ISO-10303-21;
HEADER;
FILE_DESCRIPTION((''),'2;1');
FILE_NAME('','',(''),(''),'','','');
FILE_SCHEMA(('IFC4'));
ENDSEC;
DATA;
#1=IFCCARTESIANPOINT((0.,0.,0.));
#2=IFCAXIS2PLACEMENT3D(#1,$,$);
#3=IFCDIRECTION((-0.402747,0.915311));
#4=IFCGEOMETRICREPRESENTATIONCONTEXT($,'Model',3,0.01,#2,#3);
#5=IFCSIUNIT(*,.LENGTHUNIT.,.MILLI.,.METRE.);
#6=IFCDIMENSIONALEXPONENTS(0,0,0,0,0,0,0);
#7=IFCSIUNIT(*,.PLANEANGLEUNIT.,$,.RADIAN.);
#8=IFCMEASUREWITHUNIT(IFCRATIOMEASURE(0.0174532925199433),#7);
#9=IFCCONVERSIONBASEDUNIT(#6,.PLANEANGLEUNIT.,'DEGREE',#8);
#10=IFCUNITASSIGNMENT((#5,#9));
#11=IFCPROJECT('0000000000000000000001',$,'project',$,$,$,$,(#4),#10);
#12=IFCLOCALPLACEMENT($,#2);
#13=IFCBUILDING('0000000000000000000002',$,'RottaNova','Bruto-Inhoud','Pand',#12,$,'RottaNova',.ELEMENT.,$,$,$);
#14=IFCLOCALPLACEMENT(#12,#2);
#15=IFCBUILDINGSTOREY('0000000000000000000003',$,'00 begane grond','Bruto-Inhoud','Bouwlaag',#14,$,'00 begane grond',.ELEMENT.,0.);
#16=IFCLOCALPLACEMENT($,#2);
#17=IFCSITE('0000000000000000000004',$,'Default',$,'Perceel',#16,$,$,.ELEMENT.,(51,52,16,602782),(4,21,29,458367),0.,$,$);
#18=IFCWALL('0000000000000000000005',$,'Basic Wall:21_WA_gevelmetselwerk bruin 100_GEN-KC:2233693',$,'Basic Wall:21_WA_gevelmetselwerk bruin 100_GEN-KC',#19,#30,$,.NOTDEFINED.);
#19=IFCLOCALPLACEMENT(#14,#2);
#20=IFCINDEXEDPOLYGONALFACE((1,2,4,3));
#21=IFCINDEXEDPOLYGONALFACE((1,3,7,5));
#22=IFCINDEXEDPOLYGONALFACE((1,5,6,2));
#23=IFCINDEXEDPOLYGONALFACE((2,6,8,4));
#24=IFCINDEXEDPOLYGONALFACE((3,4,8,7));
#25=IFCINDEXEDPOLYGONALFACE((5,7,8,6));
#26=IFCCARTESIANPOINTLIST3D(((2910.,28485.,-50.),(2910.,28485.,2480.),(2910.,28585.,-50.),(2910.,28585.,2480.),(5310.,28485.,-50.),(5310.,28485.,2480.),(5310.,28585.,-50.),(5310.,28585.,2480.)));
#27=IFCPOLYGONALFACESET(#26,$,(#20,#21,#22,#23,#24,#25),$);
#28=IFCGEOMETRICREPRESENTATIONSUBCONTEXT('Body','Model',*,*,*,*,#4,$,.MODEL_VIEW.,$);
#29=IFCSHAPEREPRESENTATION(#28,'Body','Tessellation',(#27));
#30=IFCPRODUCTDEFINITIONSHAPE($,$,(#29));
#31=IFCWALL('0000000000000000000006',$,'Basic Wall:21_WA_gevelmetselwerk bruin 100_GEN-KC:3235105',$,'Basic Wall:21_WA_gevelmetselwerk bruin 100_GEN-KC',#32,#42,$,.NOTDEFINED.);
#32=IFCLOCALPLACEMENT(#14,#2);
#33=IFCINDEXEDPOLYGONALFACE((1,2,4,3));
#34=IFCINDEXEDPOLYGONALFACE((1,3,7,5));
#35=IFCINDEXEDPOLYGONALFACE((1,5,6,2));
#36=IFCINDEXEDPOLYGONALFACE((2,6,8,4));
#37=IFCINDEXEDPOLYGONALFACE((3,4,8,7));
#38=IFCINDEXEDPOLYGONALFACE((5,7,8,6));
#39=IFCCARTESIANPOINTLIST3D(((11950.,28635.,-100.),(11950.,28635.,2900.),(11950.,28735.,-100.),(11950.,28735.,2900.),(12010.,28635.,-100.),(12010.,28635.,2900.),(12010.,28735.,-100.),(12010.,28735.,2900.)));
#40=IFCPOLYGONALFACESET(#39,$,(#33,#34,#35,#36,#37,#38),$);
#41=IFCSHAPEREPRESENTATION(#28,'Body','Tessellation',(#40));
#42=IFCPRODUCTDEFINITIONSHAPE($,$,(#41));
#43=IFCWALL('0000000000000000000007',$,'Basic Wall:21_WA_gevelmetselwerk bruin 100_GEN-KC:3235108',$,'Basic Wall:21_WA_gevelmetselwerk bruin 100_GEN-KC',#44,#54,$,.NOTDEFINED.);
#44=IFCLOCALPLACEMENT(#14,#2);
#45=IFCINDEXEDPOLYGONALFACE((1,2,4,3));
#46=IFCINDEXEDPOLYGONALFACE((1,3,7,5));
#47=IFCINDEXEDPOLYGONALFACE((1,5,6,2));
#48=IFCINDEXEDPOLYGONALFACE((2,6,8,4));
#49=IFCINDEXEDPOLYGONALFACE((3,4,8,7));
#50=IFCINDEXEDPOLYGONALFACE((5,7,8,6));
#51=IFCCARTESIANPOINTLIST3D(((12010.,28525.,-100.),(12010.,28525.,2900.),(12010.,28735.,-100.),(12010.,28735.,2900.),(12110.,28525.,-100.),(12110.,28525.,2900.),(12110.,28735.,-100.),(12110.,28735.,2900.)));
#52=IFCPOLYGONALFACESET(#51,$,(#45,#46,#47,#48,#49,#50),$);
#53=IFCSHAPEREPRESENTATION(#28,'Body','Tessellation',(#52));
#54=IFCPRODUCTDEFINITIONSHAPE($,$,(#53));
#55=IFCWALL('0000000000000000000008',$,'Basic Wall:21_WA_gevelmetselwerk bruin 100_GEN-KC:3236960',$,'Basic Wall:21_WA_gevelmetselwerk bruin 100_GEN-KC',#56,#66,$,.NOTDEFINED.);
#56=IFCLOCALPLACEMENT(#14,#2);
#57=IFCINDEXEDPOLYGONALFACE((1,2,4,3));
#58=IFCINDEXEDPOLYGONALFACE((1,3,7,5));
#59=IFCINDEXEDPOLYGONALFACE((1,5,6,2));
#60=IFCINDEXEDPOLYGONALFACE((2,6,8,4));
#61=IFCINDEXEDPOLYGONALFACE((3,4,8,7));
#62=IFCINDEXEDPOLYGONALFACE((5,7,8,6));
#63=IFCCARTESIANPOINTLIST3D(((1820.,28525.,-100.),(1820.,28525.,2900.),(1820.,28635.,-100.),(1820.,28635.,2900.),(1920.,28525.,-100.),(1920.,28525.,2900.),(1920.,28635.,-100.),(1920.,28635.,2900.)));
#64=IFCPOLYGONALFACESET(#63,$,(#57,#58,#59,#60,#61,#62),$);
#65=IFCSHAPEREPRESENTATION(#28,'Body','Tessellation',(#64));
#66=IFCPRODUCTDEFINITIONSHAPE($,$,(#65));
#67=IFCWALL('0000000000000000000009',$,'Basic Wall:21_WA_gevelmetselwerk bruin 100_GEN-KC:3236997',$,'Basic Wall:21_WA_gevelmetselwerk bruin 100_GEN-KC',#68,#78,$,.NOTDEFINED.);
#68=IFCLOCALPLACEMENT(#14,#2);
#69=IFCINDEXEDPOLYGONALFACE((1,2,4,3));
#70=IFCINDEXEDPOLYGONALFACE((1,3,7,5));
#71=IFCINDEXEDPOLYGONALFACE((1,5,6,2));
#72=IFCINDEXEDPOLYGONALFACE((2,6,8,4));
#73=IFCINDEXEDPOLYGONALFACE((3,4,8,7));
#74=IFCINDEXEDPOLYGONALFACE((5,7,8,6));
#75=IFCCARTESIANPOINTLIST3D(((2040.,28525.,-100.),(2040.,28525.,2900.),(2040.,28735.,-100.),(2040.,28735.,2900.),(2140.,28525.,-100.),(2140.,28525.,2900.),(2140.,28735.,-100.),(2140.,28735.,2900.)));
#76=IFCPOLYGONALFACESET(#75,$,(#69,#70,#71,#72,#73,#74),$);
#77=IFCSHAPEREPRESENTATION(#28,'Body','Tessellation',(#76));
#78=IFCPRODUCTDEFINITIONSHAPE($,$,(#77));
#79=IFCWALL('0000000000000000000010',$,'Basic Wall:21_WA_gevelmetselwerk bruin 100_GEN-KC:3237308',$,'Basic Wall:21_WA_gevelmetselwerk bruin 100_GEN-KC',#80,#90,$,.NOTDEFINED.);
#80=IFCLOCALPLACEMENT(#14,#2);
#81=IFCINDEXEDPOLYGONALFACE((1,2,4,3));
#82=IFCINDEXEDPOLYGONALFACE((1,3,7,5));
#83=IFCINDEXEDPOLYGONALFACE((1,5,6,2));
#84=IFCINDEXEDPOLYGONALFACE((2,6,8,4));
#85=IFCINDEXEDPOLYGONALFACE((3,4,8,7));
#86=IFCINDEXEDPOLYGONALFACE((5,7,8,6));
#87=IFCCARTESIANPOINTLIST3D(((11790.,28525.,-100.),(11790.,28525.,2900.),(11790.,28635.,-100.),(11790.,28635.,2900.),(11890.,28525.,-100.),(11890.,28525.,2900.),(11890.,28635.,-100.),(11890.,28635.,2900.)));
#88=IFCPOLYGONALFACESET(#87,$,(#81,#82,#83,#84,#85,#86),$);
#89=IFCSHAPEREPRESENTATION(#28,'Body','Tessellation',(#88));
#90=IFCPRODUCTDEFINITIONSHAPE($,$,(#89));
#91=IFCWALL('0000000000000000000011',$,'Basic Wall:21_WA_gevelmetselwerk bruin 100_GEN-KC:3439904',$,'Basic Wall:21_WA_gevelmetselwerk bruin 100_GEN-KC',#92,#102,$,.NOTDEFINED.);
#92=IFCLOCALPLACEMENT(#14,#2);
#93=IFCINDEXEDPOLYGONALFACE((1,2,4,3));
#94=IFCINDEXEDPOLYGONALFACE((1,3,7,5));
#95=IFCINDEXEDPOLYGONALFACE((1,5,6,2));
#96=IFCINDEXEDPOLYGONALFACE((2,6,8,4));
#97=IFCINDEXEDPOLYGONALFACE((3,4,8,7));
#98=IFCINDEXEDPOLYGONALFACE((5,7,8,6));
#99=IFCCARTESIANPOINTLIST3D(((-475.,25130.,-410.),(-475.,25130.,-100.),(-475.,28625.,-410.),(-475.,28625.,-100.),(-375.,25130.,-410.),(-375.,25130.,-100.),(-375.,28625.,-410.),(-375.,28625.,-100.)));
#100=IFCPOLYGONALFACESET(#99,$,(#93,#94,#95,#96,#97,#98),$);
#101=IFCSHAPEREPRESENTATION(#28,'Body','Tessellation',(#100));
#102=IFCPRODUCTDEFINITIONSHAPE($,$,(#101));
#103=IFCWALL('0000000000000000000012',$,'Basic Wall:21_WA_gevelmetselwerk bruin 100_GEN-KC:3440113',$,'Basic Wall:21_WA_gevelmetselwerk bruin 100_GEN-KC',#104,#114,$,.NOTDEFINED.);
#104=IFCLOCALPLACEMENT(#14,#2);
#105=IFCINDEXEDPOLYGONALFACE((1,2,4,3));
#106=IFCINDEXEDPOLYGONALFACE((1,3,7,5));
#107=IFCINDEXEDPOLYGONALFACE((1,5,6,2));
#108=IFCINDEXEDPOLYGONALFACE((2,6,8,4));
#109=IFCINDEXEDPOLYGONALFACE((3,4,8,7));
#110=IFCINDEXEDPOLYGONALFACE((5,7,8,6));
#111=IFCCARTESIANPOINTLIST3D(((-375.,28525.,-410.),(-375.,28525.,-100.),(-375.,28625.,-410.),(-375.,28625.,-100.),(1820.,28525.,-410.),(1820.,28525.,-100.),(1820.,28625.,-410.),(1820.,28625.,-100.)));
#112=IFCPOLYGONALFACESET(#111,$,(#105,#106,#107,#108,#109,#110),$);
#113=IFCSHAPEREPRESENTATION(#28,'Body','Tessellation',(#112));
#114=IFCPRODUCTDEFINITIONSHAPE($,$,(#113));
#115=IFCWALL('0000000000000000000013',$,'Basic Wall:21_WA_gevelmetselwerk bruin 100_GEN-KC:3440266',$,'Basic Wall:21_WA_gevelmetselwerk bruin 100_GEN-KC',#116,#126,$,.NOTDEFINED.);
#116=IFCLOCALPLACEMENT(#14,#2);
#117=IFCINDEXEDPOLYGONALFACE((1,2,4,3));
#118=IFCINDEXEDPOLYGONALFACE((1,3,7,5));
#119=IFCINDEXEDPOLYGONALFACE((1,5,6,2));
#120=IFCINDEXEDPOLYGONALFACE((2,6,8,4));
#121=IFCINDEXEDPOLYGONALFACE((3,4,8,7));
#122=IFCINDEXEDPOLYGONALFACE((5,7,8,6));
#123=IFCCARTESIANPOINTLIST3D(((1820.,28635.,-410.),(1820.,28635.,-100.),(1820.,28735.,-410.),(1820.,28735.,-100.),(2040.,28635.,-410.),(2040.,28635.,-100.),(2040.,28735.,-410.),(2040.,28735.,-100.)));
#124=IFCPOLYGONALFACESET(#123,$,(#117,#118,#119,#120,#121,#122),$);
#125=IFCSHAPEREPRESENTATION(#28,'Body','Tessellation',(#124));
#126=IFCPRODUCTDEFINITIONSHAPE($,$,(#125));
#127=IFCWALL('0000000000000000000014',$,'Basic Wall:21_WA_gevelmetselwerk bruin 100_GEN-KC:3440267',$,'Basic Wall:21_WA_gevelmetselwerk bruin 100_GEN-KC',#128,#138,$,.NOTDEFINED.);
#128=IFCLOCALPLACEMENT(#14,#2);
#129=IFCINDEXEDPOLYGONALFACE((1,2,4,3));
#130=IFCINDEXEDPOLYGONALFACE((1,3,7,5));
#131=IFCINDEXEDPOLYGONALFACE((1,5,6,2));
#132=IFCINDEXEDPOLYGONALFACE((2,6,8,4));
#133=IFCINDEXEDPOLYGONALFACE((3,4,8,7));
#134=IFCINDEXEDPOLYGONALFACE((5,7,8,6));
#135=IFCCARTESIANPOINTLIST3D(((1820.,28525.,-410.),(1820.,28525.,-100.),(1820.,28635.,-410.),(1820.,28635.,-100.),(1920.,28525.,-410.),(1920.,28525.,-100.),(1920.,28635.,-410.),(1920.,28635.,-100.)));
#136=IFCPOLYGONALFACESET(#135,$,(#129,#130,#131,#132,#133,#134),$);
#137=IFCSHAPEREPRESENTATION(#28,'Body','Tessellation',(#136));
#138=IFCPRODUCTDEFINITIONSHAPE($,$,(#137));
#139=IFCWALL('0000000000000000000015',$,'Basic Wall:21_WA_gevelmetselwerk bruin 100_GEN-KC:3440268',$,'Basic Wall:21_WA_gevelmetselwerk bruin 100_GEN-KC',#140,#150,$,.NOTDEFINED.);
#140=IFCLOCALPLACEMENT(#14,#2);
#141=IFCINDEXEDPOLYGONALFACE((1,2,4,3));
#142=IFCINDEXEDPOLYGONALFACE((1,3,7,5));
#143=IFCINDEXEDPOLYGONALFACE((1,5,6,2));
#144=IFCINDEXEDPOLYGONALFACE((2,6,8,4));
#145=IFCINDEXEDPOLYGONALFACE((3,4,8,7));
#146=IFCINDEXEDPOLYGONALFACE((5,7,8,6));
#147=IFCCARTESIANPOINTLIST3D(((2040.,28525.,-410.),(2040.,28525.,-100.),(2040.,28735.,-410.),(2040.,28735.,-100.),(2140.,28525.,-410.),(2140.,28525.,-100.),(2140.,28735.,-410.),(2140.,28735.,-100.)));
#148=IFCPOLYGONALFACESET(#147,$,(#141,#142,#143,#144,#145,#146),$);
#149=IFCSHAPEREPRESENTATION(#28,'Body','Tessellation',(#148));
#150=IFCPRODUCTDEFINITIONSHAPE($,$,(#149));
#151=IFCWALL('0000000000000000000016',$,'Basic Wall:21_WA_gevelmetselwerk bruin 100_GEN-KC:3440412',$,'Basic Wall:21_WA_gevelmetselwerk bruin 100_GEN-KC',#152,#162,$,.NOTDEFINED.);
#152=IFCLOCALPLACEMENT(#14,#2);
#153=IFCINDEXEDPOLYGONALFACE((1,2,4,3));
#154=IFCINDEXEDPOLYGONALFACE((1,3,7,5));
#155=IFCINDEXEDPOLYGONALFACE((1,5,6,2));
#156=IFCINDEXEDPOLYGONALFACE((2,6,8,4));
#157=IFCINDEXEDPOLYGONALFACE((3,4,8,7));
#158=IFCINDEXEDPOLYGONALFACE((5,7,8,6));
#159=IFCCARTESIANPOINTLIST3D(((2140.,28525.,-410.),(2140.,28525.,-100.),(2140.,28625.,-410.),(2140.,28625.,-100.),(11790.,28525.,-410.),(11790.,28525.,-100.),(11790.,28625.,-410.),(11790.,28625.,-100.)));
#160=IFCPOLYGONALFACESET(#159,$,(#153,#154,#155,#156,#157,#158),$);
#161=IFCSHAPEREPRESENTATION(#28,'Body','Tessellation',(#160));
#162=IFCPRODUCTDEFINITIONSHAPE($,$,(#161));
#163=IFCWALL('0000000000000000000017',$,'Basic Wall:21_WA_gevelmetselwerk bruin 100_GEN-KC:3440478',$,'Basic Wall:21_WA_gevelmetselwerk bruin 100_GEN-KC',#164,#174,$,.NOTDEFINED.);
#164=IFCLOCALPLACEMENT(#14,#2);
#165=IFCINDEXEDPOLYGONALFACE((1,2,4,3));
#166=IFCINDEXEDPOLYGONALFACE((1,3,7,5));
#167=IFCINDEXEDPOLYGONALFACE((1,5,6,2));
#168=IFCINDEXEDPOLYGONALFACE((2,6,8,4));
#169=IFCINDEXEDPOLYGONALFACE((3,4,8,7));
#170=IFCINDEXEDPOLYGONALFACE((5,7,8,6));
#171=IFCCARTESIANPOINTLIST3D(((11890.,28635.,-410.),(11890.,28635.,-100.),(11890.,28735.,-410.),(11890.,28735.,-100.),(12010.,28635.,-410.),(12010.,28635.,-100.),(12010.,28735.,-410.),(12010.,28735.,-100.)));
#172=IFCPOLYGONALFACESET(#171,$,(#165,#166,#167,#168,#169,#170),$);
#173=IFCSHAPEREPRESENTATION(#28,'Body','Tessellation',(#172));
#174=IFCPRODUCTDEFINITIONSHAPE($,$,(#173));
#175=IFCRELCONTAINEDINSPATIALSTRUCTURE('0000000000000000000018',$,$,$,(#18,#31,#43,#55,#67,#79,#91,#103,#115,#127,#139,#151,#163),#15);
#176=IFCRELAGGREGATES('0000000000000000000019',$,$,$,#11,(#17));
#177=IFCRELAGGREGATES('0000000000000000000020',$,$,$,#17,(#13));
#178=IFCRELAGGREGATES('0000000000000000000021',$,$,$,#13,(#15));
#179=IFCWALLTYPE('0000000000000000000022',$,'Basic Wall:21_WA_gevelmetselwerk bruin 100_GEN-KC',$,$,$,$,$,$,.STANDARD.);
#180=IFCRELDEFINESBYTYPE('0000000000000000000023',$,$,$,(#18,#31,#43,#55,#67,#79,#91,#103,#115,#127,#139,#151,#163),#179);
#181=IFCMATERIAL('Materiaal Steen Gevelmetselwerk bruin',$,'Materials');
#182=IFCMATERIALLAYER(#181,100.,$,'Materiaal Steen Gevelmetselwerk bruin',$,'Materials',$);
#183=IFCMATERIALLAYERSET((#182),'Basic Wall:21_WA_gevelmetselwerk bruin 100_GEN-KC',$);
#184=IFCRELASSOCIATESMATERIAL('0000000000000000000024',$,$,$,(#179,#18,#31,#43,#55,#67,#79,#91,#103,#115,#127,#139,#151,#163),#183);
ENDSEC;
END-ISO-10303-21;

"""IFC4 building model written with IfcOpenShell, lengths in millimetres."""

from ifc_helpers import new_model, entity, si_unit, converted_unit, direction, frame, frame_2d, origin, place, context, subcontext, project, spatial, rectangle, extrude, material, layer, layer_set, type_object, element, save


model = new_model("IFC4")

# Units and contexts
model_context = context("Model", 3, precision=0.01, world=origin(), true_north=direction((-0.402747, 0.915311)))
body_context = subcontext(model_context, "Body", "Model", "MODEL_VIEW")
ifc_project = project(units=[si_unit("LENGTHUNIT", "METRE", prefix="MILLI"), converted_unit("PLANEANGLEUNIT", "DEGREE", entity("IfcRatioMeasure", 0.0174532925199433), si_unit("PLANEANGLEUNIT", "RADIAN"), dimensions=[0, 0, 0, 0, 0, 0, 0])], contexts=[model_context])

# Site, building, storey
site_placement = place(None, origin())
site = spatial("IfcSite", under=ifc_project, at=site_placement, Name="Default", ObjectType="Perceel", CompositionType="ELEMENT", RefLatitude=(51, 52, 16, 602782), RefLongitude=(4, 21, 29, 458367), RefElevation=0.0)
building_placement = place(None, origin())
building = spatial("IfcBuilding", under=site, at=building_placement, Name="RottaNova", Description="Bruto-Inhoud", ObjectType="Pand", LongName="RottaNova", CompositionType="ELEMENT")
storey_placement = place(building_placement, origin())
storey = spatial("IfcBuildingStorey", under=building, at=storey_placement, Name="00 begane grond", Description="Bruto-Inhoud", ObjectType="Bouwlaag", LongName="00 begane grond", CompositionType="ELEMENT", Elevation=0.0)

# Walls
ifc_material_1 = material(Name="Materiaal Steen Gevelmetselwerk bruin", Category="Materials")
ifc_layer_1 = layer(ifc_material_1, 100.0, Name="Materiaal Steen Gevelmetselwerk bruin", Category="Materials")
ifc_layer_set_1 = layer_set([ifc_layer_1], Name="Basic Wall:21_WA_gevelmetselwerk bruin 100_GEN-KC")
wall_type_1 = type_object("IfcWallType", Name="Basic Wall:21_WA_gevelmetselwerk bruin 100_GEN-KC", PredefinedType="STANDARD", material=ifc_layer_set_1)
wall_1_placement = place(storey_placement, frame((5310.0, 28535.0, -50.0), z_axis=(0.0, 0.0, 1.0), x_axis=(-1.0, 0.0, 0.0)))
element("IfcWall", 1, at=wall_1_placement, inside=storey, type_object=wall_type_1, material=ifc_layer_set_1, Name="Basic Wall:21_WA_gevelmetselwerk bruin 100_GEN-KC:2233693", ObjectType="Basic Wall:21_WA_gevelmetselwerk bruin 100_GEN-KC", PredefinedType="NOTDEFINED", context=body_context, shape_type="SweptSolid", body=[
    extrude(rectangle(XDim=2400.0, YDim=100.0, at=frame_2d((1200.0, 0.0), x_axis=(-1.0, 0.0))), origin(), (0.0, 0.0, 1.0), 2530.0),
])
wall_2_placement = place(storey_placement, frame((12010.0, 28685.0, -100.0), z_axis=(0.0, 0.0, 1.0), x_axis=(-1.0, 0.0, 0.0)))
element("IfcWall", 2, at=wall_2_placement, inside=storey, type_object=wall_type_1, material=ifc_layer_set_1, Name="Basic Wall:21_WA_gevelmetselwerk bruin 100_GEN-KC:3235105", ObjectType="Basic Wall:21_WA_gevelmetselwerk bruin 100_GEN-KC", PredefinedType="NOTDEFINED", context=body_context, shape_type="SweptSolid", body=[
    extrude(rectangle(XDim=60.0, YDim=100.0, at=frame_2d((30.0, 0.0), x_axis=(-1.0, 0.0))), origin(), (0.0, 0.0, 1.0), 3000.0),
])
wall_3_placement = place(storey_placement, frame((12060.0, 28735.0, -100.0), z_axis=(0.0, 0.0, 1.0), x_axis=(0.0, -1.0, 0.0)))
element("IfcWall", 3, at=wall_3_placement, inside=storey, type_object=wall_type_1, material=ifc_layer_set_1, Name="Basic Wall:21_WA_gevelmetselwerk bruin 100_GEN-KC:3235108", ObjectType="Basic Wall:21_WA_gevelmetselwerk bruin 100_GEN-KC", PredefinedType="NOTDEFINED", context=body_context, shape_type="SweptSolid", body=[
    extrude(rectangle(XDim=210.0, YDim=100.0, at=frame_2d((105.0, 0.0), x_axis=(-1.0, 0.0))), origin(), (0.0, 0.0, 1.0), 3000.0),
])
wall_4_placement = place(storey_placement, frame((1870.0, 28635.0, -100.0), z_axis=(0.0, 0.0, 1.0), x_axis=(0.0, -1.0, 0.0)))
element("IfcWall", 4, at=wall_4_placement, inside=storey, type_object=wall_type_1, material=ifc_layer_set_1, Name="Basic Wall:21_WA_gevelmetselwerk bruin 100_GEN-KC:3236960", ObjectType="Basic Wall:21_WA_gevelmetselwerk bruin 100_GEN-KC", PredefinedType="NOTDEFINED", context=body_context, shape_type="SweptSolid", body=[
    extrude(rectangle(XDim=110.0, YDim=100.0, at=frame_2d((55.0, 0.0), x_axis=(-1.0, 0.0))), origin(), (0.0, 0.0, 1.0), 3000.0),
])
wall_5_placement = place(storey_placement, frame((2090.0, 28735.0, -100.0), z_axis=(0.0, 0.0, 1.0), x_axis=(0.0, -1.0, 0.0)))
element("IfcWall", 5, at=wall_5_placement, inside=storey, type_object=wall_type_1, material=ifc_layer_set_1, Name="Basic Wall:21_WA_gevelmetselwerk bruin 100_GEN-KC:3236997", ObjectType="Basic Wall:21_WA_gevelmetselwerk bruin 100_GEN-KC", PredefinedType="NOTDEFINED", context=body_context, shape_type="SweptSolid", body=[
    extrude(rectangle(XDim=210.0, YDim=100.0, at=frame_2d((105.0, 0.0), x_axis=(-1.0, 0.0))), origin(), (0.0, 0.0, 1.0), 3000.0),
])
wall_6_placement = place(storey_placement, frame((11840.0, 28635.0, -100.0), z_axis=(0.0, 0.0, 1.0), x_axis=(0.0, -1.0, 0.0)))
element("IfcWall", 6, at=wall_6_placement, inside=storey, type_object=wall_type_1, material=ifc_layer_set_1, Name="Basic Wall:21_WA_gevelmetselwerk bruin 100_GEN-KC:3237308", ObjectType="Basic Wall:21_WA_gevelmetselwerk bruin 100_GEN-KC", PredefinedType="NOTDEFINED", context=body_context, shape_type="SweptSolid", body=[
    extrude(rectangle(XDim=110.0, YDim=100.0, at=frame_2d((55.0, 0.0), x_axis=(-1.0, 0.0))), origin(), (0.0, 0.0, 1.0), 3000.0),
])
wall_7_placement = place(storey_placement, frame((-425.0, 25130.0, -410.0), z_axis=(0.0, 0.0, 1.0), x_axis=(0.0, 1.0, 0.0)))
element("IfcWall", 7, at=wall_7_placement, inside=storey, type_object=wall_type_1, material=ifc_layer_set_1, Name="Basic Wall:21_WA_gevelmetselwerk bruin 100_GEN-KC:3439904", ObjectType="Basic Wall:21_WA_gevelmetselwerk bruin 100_GEN-KC", PredefinedType="NOTDEFINED", context=body_context, shape_type="SweptSolid", body=[
    extrude(rectangle(XDim=3495.0, YDim=100.0, at=frame_2d((1747.5, 0.0), x_axis=(-1.0, 0.0))), origin(), (0.0, 0.0, 1.0), 310.0),
])
wall_8_placement = place(storey_placement, frame((1820.0, 28575.0, -410.0), z_axis=(0.0, 0.0, 1.0), x_axis=(-1.0, 0.0, 0.0)))
element("IfcWall", 8, at=wall_8_placement, inside=storey, type_object=wall_type_1, material=ifc_layer_set_1, Name="Basic Wall:21_WA_gevelmetselwerk bruin 100_GEN-KC:3440113", ObjectType="Basic Wall:21_WA_gevelmetselwerk bruin 100_GEN-KC", PredefinedType="NOTDEFINED", context=body_context, shape_type="SweptSolid", body=[
    extrude(rectangle(XDim=2195.0, YDim=100.0, at=frame_2d((1097.5, 0.0), x_axis=(-1.0, 0.0))), origin(), (0.0, 0.0, 1.0), 310.0),
])
wall_9_placement = place(storey_placement, frame((1820.0, 28685.0, -410.0)))
element("IfcWall", 9, at=wall_9_placement, inside=storey, type_object=wall_type_1, material=ifc_layer_set_1, Name="Basic Wall:21_WA_gevelmetselwerk bruin 100_GEN-KC:3440266", ObjectType="Basic Wall:21_WA_gevelmetselwerk bruin 100_GEN-KC", PredefinedType="NOTDEFINED", context=body_context, shape_type="SweptSolid", body=[
    extrude(rectangle(XDim=220.0, YDim=100.0, at=frame_2d((110.0, 0.0), x_axis=(-1.0, 0.0))), origin(), (0.0, 0.0, 1.0), 310.0),
])
wall_10_placement = place(storey_placement, frame((1870.0, 28635.0, -410.0), z_axis=(0.0, 0.0, 1.0), x_axis=(0.0, -1.0, 0.0)))
element("IfcWall", 10, at=wall_10_placement, inside=storey, type_object=wall_type_1, material=ifc_layer_set_1, Name="Basic Wall:21_WA_gevelmetselwerk bruin 100_GEN-KC:3440267", ObjectType="Basic Wall:21_WA_gevelmetselwerk bruin 100_GEN-KC", PredefinedType="NOTDEFINED", context=body_context, shape_type="SweptSolid", body=[
    extrude(rectangle(XDim=110.0, YDim=100.0, at=frame_2d((55.0, 0.0), x_axis=(-1.0, 0.0))), origin(), (0.0, 0.0, 1.0), 310.0),
])
wall_11_placement = place(storey_placement, frame((2090.0, 28735.0, -410.0), z_axis=(0.0, 0.0, 1.0), x_axis=(0.0, -1.0, 0.0)))
element("IfcWall", 11, at=wall_11_placement, inside=storey, type_object=wall_type_1, material=ifc_layer_set_1, Name="Basic Wall:21_WA_gevelmetselwerk bruin 100_GEN-KC:3440268", ObjectType="Basic Wall:21_WA_gevelmetselwerk bruin 100_GEN-KC", PredefinedType="NOTDEFINED", context=body_context, shape_type="SweptSolid", body=[
    extrude(rectangle(XDim=210.0, YDim=100.0, at=frame_2d((105.0, 0.0), x_axis=(-1.0, 0.0))), origin(), (0.0, 0.0, 1.0), 310.0),
])
wall_12_placement = place(storey_placement, frame((11790.0, 28575.0, -410.0), z_axis=(0.0, 0.0, 1.0), x_axis=(-1.0, 0.0, 0.0)))
element("IfcWall", 12, at=wall_12_placement, inside=storey, type_object=wall_type_1, material=ifc_layer_set_1, Name="Basic Wall:21_WA_gevelmetselwerk bruin 100_GEN-KC:3440412", ObjectType="Basic Wall:21_WA_gevelmetselwerk bruin 100_GEN-KC", PredefinedType="NOTDEFINED", context=body_context, shape_type="SweptSolid", body=[
    extrude(rectangle(XDim=9650.0, YDim=100.0, at=frame_2d((4825.0, 0.0), x_axis=(-1.0, 0.0))), origin(), (0.0, 0.0, 1.0), 310.0),
])
wall_13_placement = place(storey_placement, frame((12010.0, 28685.0, -410.0), z_axis=(0.0, 0.0, 1.0), x_axis=(-1.0, 0.0, 0.0)))
element("IfcWall", 13, at=wall_13_placement, inside=storey, type_object=wall_type_1, material=ifc_layer_set_1, Name="Basic Wall:21_WA_gevelmetselwerk bruin 100_GEN-KC:3440478", ObjectType="Basic Wall:21_WA_gevelmetselwerk bruin 100_GEN-KC", PredefinedType="NOTDEFINED", context=body_context, shape_type="SweptSolid", body=[
    extrude(rectangle(XDim=120.0, YDim=100.0, at=frame_2d((60.0, 0.0), x_axis=(-1.0, 0.0))), origin(), (0.0, 0.0, 1.0), 310.0),
])

save(model, "model.ifc")
